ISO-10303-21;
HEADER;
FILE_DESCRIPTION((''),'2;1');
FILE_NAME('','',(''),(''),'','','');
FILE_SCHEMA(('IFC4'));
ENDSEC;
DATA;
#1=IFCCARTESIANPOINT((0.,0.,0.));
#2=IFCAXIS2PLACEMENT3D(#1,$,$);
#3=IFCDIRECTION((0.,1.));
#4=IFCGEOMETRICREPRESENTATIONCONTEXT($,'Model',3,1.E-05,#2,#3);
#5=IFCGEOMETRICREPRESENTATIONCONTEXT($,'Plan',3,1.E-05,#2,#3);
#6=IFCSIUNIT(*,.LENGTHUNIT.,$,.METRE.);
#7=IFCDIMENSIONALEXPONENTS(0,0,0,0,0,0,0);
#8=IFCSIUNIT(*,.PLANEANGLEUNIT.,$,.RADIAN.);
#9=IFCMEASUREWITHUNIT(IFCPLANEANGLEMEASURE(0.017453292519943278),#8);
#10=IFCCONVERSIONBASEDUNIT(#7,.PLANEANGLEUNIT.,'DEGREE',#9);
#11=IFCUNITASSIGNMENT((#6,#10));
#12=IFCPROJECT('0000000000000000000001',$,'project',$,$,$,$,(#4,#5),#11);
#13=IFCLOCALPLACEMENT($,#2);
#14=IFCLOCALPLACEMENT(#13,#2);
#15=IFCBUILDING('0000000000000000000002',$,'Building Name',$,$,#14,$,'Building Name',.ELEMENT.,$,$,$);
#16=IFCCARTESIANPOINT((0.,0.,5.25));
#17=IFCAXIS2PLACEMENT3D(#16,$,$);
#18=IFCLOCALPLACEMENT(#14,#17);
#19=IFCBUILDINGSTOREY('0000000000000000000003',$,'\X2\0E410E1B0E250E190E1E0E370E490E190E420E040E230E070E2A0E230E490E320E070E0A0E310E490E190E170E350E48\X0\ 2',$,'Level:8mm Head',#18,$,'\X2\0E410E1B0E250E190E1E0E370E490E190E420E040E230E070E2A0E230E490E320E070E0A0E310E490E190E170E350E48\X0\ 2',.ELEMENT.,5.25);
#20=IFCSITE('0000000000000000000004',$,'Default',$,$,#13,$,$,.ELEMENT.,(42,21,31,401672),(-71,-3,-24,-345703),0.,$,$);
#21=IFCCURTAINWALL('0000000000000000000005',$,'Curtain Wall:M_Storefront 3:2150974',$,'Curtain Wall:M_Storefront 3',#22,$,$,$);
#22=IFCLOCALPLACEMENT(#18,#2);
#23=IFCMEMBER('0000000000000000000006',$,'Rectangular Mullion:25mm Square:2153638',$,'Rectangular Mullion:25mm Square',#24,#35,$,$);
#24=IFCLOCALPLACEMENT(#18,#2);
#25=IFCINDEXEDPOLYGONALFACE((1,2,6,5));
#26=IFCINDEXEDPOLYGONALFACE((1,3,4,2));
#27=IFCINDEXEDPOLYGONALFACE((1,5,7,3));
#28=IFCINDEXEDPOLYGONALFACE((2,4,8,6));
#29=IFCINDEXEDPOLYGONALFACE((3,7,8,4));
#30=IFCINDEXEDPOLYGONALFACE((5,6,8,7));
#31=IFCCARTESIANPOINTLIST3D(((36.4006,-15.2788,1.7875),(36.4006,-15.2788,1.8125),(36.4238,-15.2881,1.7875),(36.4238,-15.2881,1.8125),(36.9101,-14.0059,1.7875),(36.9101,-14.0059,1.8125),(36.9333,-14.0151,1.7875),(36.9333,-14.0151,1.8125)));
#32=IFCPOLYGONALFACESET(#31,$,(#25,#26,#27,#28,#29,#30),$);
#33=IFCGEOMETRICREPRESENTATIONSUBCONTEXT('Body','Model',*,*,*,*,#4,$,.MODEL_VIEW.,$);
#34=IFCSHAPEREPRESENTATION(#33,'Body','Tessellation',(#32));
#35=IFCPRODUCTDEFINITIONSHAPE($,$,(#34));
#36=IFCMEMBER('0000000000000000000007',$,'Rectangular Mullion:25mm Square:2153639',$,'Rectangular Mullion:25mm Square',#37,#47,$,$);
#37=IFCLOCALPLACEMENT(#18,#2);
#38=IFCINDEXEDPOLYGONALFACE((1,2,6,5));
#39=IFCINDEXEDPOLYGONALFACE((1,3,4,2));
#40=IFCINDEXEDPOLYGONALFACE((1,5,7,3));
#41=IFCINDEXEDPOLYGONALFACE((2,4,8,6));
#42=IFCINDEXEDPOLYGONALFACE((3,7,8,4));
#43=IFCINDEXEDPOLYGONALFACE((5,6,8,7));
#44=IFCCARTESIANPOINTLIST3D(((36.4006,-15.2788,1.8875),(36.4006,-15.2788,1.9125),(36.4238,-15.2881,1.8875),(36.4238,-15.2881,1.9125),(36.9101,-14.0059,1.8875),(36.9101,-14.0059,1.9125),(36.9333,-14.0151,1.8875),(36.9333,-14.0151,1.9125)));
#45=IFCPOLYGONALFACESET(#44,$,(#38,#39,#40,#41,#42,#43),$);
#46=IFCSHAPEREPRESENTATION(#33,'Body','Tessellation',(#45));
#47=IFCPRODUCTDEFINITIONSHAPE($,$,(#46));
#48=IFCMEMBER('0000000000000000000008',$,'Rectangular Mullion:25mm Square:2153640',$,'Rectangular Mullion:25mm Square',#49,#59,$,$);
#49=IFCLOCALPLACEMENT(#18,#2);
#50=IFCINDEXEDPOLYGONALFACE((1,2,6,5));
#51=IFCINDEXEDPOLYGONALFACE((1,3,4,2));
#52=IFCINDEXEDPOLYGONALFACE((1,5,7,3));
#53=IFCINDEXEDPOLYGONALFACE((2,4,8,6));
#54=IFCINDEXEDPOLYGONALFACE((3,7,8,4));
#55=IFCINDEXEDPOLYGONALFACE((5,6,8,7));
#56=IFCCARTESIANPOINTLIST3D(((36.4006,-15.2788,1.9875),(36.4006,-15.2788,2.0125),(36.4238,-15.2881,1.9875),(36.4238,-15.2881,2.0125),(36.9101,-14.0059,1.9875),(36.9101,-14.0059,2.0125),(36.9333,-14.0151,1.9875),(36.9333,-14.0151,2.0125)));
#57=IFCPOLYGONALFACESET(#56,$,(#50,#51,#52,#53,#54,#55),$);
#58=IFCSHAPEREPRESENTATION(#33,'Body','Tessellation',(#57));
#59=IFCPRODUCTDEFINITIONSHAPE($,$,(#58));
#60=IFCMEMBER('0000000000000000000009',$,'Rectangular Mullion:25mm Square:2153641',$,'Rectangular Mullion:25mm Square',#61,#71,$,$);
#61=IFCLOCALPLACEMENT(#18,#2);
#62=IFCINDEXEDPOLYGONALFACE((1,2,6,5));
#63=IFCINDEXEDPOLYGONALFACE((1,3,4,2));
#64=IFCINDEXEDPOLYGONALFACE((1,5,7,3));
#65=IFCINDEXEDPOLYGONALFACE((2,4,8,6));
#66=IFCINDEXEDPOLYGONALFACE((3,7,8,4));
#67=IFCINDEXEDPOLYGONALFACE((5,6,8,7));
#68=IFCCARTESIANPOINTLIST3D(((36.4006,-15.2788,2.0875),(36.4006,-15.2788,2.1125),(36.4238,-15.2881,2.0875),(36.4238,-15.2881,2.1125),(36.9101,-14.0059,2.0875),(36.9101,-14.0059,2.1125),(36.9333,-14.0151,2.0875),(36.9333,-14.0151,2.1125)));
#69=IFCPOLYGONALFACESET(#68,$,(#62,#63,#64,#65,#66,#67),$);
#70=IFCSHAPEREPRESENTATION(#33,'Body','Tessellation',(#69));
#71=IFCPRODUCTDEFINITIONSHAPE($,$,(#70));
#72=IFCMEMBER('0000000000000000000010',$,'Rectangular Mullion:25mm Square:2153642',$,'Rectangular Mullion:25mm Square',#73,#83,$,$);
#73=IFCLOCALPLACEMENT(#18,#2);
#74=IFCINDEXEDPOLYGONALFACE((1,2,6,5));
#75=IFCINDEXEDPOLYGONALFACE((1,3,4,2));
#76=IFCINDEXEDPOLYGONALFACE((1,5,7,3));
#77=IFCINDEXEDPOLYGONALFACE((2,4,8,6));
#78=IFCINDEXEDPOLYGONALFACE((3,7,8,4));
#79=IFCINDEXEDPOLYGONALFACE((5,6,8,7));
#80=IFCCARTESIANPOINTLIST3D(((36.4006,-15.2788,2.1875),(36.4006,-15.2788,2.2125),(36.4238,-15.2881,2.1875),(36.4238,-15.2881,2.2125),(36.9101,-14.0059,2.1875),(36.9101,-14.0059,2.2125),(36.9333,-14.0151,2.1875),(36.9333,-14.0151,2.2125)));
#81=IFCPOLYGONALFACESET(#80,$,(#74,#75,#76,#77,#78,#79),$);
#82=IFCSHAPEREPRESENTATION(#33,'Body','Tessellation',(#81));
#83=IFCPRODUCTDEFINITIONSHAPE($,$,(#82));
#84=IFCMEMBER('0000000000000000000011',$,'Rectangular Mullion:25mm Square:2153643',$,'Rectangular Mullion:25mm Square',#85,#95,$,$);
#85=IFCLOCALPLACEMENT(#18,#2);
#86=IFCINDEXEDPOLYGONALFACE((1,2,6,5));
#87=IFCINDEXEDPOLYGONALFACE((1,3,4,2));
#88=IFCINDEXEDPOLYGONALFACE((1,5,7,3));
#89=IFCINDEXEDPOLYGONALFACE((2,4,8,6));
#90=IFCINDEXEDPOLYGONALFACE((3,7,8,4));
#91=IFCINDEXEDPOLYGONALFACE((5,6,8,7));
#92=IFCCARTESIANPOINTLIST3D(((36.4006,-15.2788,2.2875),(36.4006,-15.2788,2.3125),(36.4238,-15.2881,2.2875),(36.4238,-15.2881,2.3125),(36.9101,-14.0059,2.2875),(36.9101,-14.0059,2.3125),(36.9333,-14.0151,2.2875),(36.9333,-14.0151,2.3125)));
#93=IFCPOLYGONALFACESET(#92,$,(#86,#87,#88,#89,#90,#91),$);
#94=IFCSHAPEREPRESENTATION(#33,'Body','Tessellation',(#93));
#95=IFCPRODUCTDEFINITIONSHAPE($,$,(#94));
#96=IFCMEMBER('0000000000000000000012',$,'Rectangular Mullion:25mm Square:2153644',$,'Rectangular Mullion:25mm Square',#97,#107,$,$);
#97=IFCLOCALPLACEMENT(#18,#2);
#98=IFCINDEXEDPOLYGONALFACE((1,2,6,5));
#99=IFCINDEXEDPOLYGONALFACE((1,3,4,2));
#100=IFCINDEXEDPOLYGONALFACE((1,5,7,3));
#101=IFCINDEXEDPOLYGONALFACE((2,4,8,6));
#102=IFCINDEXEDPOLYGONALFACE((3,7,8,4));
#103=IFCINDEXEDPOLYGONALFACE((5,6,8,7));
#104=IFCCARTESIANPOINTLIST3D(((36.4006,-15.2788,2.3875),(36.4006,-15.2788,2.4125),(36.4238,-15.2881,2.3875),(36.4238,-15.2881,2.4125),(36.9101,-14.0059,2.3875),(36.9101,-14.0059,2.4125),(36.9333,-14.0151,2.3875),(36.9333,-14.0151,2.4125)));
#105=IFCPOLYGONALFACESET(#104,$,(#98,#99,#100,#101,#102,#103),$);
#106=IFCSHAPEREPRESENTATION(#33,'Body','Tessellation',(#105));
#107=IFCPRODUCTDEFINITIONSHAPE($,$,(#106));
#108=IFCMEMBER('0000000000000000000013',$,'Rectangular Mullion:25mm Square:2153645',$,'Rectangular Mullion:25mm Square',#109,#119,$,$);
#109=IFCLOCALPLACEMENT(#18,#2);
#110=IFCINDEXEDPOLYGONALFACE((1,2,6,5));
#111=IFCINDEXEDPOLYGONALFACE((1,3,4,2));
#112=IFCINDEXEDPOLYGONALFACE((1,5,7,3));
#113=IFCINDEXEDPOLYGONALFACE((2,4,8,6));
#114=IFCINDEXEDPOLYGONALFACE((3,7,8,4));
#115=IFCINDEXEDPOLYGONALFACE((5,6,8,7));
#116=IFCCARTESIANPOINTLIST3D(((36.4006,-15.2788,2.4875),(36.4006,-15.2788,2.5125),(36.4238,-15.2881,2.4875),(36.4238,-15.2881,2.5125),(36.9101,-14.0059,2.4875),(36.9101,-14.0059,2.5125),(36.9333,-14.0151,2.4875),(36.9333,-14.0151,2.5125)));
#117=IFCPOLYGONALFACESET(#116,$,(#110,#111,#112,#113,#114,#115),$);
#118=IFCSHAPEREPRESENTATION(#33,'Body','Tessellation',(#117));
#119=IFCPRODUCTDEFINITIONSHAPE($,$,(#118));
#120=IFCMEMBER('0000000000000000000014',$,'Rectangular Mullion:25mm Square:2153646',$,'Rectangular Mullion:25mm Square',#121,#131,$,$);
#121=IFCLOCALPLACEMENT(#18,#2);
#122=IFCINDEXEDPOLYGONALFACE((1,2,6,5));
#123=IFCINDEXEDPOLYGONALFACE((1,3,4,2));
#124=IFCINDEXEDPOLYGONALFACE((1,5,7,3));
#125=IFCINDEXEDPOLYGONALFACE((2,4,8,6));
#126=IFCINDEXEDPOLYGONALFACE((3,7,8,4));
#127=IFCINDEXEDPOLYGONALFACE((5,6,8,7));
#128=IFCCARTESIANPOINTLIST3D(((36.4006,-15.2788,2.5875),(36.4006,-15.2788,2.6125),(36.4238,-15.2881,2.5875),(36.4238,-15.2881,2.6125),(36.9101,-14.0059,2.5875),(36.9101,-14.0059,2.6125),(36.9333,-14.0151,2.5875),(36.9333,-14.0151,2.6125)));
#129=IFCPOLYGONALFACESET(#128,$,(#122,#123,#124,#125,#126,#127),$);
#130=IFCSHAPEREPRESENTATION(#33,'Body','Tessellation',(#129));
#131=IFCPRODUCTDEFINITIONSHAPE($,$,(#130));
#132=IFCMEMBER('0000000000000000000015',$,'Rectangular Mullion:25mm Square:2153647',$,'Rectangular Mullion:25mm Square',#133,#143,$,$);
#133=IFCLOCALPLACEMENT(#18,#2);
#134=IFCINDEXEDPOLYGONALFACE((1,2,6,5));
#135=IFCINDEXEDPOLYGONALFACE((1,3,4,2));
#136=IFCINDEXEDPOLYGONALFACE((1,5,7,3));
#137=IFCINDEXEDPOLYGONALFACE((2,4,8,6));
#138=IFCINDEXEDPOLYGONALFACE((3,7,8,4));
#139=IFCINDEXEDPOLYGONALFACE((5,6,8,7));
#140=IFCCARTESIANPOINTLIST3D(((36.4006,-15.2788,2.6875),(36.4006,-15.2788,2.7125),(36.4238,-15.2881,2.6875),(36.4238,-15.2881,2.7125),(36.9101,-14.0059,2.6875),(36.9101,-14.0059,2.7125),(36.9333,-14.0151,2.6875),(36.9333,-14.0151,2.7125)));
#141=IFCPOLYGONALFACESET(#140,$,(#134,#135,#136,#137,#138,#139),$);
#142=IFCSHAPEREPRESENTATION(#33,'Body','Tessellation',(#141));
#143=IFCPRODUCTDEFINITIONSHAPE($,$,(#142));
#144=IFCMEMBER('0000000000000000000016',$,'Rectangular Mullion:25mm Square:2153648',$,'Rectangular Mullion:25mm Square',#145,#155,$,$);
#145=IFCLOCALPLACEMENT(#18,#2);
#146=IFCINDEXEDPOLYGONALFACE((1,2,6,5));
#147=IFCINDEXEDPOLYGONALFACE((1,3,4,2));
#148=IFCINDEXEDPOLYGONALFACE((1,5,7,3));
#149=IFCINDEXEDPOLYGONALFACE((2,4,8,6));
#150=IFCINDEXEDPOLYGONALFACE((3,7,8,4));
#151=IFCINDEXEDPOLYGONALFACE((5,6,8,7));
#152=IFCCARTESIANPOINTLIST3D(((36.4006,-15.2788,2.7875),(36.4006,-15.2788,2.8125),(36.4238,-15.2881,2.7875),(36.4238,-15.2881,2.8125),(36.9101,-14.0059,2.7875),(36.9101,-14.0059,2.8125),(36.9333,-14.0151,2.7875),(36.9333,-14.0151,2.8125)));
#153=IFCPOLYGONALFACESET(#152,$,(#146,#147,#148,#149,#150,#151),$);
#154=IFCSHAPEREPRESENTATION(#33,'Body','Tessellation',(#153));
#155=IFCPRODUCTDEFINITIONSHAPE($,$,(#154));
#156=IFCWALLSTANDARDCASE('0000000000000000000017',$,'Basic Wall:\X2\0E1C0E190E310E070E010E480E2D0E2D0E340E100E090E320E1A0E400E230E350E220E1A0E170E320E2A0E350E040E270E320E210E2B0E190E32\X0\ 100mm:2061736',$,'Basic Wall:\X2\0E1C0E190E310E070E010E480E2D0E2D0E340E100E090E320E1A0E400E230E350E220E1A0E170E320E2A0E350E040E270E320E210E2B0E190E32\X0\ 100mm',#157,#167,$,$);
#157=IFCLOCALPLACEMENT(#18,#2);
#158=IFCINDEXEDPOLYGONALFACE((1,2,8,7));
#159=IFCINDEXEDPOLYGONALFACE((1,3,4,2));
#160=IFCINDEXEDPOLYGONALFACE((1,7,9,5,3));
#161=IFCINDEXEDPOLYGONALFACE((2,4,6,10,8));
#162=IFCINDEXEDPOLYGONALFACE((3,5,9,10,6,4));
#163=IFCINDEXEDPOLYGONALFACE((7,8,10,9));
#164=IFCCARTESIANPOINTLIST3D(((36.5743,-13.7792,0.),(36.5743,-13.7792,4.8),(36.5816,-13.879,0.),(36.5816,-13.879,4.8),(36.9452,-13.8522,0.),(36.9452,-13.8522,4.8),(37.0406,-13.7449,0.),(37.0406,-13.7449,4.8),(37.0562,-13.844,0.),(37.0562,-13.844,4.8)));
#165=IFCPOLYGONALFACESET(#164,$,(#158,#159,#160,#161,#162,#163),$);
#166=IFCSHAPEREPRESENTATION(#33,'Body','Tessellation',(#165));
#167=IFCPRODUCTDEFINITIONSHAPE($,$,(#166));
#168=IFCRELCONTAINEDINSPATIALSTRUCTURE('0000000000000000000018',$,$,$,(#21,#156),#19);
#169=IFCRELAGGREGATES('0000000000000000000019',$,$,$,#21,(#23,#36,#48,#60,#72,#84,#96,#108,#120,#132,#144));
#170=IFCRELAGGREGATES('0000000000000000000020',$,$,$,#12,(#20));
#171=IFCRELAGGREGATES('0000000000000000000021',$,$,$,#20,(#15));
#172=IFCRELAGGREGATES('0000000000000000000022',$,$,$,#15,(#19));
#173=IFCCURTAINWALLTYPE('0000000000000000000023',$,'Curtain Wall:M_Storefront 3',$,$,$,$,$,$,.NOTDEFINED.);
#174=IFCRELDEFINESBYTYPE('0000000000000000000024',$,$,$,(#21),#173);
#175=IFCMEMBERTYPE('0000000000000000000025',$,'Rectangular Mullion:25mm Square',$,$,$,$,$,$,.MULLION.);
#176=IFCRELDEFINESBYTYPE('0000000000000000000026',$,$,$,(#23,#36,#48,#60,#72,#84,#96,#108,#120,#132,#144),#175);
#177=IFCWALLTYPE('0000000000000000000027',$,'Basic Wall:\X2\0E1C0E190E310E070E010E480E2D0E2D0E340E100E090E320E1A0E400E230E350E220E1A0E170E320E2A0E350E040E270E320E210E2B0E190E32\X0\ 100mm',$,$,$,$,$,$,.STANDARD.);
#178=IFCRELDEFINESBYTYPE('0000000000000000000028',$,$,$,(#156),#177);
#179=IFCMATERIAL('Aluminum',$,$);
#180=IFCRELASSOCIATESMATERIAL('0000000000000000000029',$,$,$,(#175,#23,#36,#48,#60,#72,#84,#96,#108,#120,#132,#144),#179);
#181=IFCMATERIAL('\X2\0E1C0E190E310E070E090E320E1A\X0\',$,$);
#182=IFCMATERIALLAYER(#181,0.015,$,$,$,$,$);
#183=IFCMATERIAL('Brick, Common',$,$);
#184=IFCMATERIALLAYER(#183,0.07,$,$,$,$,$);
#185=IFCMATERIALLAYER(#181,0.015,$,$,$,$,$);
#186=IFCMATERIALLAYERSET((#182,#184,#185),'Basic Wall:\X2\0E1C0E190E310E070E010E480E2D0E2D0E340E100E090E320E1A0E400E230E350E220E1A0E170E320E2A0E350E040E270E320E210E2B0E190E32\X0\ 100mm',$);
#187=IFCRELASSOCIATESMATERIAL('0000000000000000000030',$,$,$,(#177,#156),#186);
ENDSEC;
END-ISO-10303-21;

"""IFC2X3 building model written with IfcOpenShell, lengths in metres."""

from ifc_helpers import new_model, entity, si_unit, converted_unit, direction, frame, frame_2d, origin, place, context, subcontext, project, spatial, polyline, rectangle, outline, extrude, source, transform, mapped, material, layer, layer_set, layer_usage, type_object, type_shapes, element, aggregate, save


model = new_model("IFC2X3")

# Units and contexts
model_context = context("Model", 3, precision=1e-05, world=origin(), true_north=direction((0.0, 1.0)))
plan_context = context("Plan", 3, precision=1e-05, world=origin(), true_north=direction((0.0, 1.0)))
body_context = subcontext(model_context, "Body", "Model", "MODEL_VIEW")
ifc_project = project(units=[si_unit("LENGTHUNIT", "METRE"), converted_unit("PLANEANGLEUNIT", "DEGREE", entity("IfcPlaneAngleMeasure", 0.017453292519943278), si_unit("PLANEANGLEUNIT", "RADIAN"), dimensions=[0, 0, 0, 0, 0, 0, 0])], contexts=[model_context, plan_context])

# Site, building, storey
site_placement = place(None, origin())
site = spatial("IfcSite", under=ifc_project, at=site_placement, Name="Default", CompositionType="ELEMENT", RefLatitude=(42, 21, 31, 401672), RefLongitude=(-71, -3, -24, -345703), RefElevation=0.0)
building_placement = place(site_placement, origin())
building = spatial("IfcBuilding", under=site, at=building_placement, Name="Building Name", LongName="Building Name", CompositionType="ELEMENT")
storey_placement = place(building_placement, frame((0.0, 0.0, 5.25)))
storey = spatial("IfcBuildingStorey", under=building, at=storey_placement, Name="แปลนพื้นโครงสร้างชั้นที่ 2", ObjectType="Level:8mm Head", LongName="แปลนพื้นโครงสร้างชั้นที่ 2", CompositionType="ELEMENT", Elevation=5.25)

# Curtain wall, members
curtain_wall_type = type_object("IfcCurtainWallType", Name="Curtain Wall:M_Storefront 3", PredefinedType="NOTDEFINED")
curtain_wall_placement = place(storey_placement, frame((0.0, 0.0, -5.25)))
curtain_wall = element("IfcCurtainWall", 1, at=curtain_wall_placement, inside=storey, type_object=curtain_wall_type, Name="Curtain Wall:M_Storefront 3:2150974", ObjectType="Curtain Wall:M_Storefront 3")
ifc_material_1 = material(Name="Aluminum")
member_type_1 = type_object("IfcMemberType", Name="Rectangular Mullion:25mm Square", PredefinedType="MULLION", material=ifc_material_1)
shared_shape_1 = source(origin(), body_context, "Body", "SweptSolid", [
    extrude(rectangle(XDim=0.025, YDim=0.025, at=frame_2d((0.0, 0.0), x_axis=(1.0, 0.0))), frame((0.0, 0.0, -1.3712), z_axis=(0.0, 0.0, 1.0), x_axis=(-1.0, 0.0, 0.0)), (0.0, 0.0, 1.0), 1.3712),
])
type_shapes(member_type_1, [shared_shape_1])
member_1_placement = place(curtain_wall_placement, frame((36.9217, -14.0105, 7.05), z_axis=(0.371573, 0.928404, 0.0), x_axis=(0.0, 0.0, 1.0)))
member_1 = element("IfcMember", 2, at=member_1_placement, type_object=member_type_1, material=ifc_material_1, Name="Rectangular Mullion:25mm Square:2153638", ObjectType="Rectangular Mullion:25mm Square", context=body_context, shape_type="MappedRepresentation", body=[
    mapped(shared_shape_1, transform((0.0, 0.0, 0.0), scale=1.0)),
])
member_2_placement = place(curtain_wall_placement, frame((36.9217, -14.0105, 7.15), z_axis=(0.371573, 0.928404, 0.0), x_axis=(0.0, 0.0, 1.0)))
member_2 = element("IfcMember", 3, at=member_2_placement, type_object=member_type_1, material=ifc_material_1, Name="Rectangular Mullion:25mm Square:2153639", ObjectType="Rectangular Mullion:25mm Square", context=body_context, shape_type="MappedRepresentation", body=[
    mapped(shared_shape_1, transform((0.0, 0.0, 0.0), scale=1.0)),
])
member_3_placement = place(curtain_wall_placement, frame((36.9217, -14.0105, 7.25), z_axis=(0.371573, 0.928404, 0.0), x_axis=(0.0, 0.0, 1.0)))
member_3 = element("IfcMember", 4, at=member_3_placement, type_object=member_type_1, material=ifc_material_1, Name="Rectangular Mullion:25mm Square:2153640", ObjectType="Rectangular Mullion:25mm Square", context=body_context, shape_type="MappedRepresentation", body=[
    mapped(shared_shape_1, transform((0.0, 0.0, 0.0), scale=1.0)),
])
member_4_placement = place(curtain_wall_placement, frame((36.9217, -14.0105, 7.35), z_axis=(0.371573, 0.928404, 0.0), x_axis=(0.0, 0.0, 1.0)))
member_4 = element("IfcMember", 5, at=member_4_placement, type_object=member_type_1, material=ifc_material_1, Name="Rectangular Mullion:25mm Square:2153641", ObjectType="Rectangular Mullion:25mm Square", context=body_context, shape_type="MappedRepresentation", body=[
    mapped(shared_shape_1, transform((0.0, 0.0, 0.0), scale=1.0)),
])
member_5_placement = place(curtain_wall_placement, frame((36.9217, -14.0105, 7.45), z_axis=(0.371573, 0.928404, 0.0), x_axis=(0.0, 0.0, 1.0)))
member_5 = element("IfcMember", 6, at=member_5_placement, type_object=member_type_1, material=ifc_material_1, Name="Rectangular Mullion:25mm Square:2153642", ObjectType="Rectangular Mullion:25mm Square", context=body_context, shape_type="MappedRepresentation", body=[
    mapped(shared_shape_1, transform((0.0, 0.0, 0.0), scale=1.0)),
])
member_6_placement = place(curtain_wall_placement, frame((36.9217, -14.0105, 7.55), z_axis=(0.371573, 0.928404, 0.0), x_axis=(0.0, 0.0, 1.0)))
member_6 = element("IfcMember", 7, at=member_6_placement, type_object=member_type_1, material=ifc_material_1, Name="Rectangular Mullion:25mm Square:2153643", ObjectType="Rectangular Mullion:25mm Square", context=body_context, shape_type="MappedRepresentation", body=[
    mapped(shared_shape_1, transform((0.0, 0.0, 0.0), scale=1.0)),
])
member_7_placement = place(curtain_wall_placement, frame((36.9217, -14.0105, 7.65), z_axis=(0.371573, 0.928404, 0.0), x_axis=(0.0, 0.0, 1.0)))
member_7 = element("IfcMember", 8, at=member_7_placement, type_object=member_type_1, material=ifc_material_1, Name="Rectangular Mullion:25mm Square:2153644", ObjectType="Rectangular Mullion:25mm Square", context=body_context, shape_type="MappedRepresentation", body=[
    mapped(shared_shape_1, transform((0.0, 0.0, 0.0), scale=1.0)),
])
member_8_placement = place(curtain_wall_placement, frame((36.9217, -14.0105, 7.75), z_axis=(0.371573, 0.928404, 0.0), x_axis=(0.0, 0.0, 1.0)))
member_8 = element("IfcMember", 9, at=member_8_placement, type_object=member_type_1, material=ifc_material_1, Name="Rectangular Mullion:25mm Square:2153645", ObjectType="Rectangular Mullion:25mm Square", context=body_context, shape_type="MappedRepresentation", body=[
    mapped(shared_shape_1, transform((0.0, 0.0, 0.0), scale=1.0)),
])
member_9_placement = place(curtain_wall_placement, frame((36.9217, -14.0105, 7.85), z_axis=(0.371573, 0.928404, 0.0), x_axis=(0.0, 0.0, 1.0)))
member_9 = element("IfcMember", 10, at=member_9_placement, type_object=member_type_1, material=ifc_material_1, Name="Rectangular Mullion:25mm Square:2153646", ObjectType="Rectangular Mullion:25mm Square", context=body_context, shape_type="MappedRepresentation", body=[
    mapped(shared_shape_1, transform((0.0, 0.0, 0.0), scale=1.0)),
])
member_10_placement = place(curtain_wall_placement, frame((36.9217, -14.0105, 7.95), z_axis=(0.371573, 0.928404, 0.0), x_axis=(0.0, 0.0, 1.0)))
member_10 = element("IfcMember", 11, at=member_10_placement, type_object=member_type_1, material=ifc_material_1, Name="Rectangular Mullion:25mm Square:2153647", ObjectType="Rectangular Mullion:25mm Square", context=body_context, shape_type="MappedRepresentation", body=[
    mapped(shared_shape_1, transform((0.0, 0.0, 0.0), scale=1.0)),
])
member_11_placement = place(curtain_wall_placement, frame((36.9217, -14.0105, 8.05), z_axis=(0.371573, 0.928404, 0.0), x_axis=(0.0, 0.0, 1.0)))
member_11 = element("IfcMember", 12, at=member_11_placement, type_object=member_type_1, material=ifc_material_1, Name="Rectangular Mullion:25mm Square:2153648", ObjectType="Rectangular Mullion:25mm Square", context=body_context, shape_type="MappedRepresentation", body=[
    mapped(shared_shape_1, transform((0.0, 0.0, 0.0), scale=1.0)),
])
aggregate(curtain_wall, [member_1, member_2, member_3, member_4, member_5, member_6, member_7, member_8, member_9, member_10, member_11])

# Wall
ifc_material_2 = material(Name="ผนังฉาบ")
ifc_layer_1 = layer(ifc_material_2, 0.015)
ifc_material_3 = material(Name="Brick, Common")
ifc_layer_2 = layer(ifc_material_3, 0.07)
ifc_layer_3 = layer(ifc_material_2, 0.015)
ifc_layer_set = layer_set([ifc_layer_1, ifc_layer_2, ifc_layer_3], Name="Basic Wall:ผนังก่ออิฐฉาบเรียบทาสีความหนา 100mm")
ifc_layer_usage = layer_usage(ifc_layer_set, "AXIS2", "POSITIVE", -0.05)
wall_type = type_object("IfcWallType", Name="Basic Wall:ผนังก่ออิฐฉาบเรียบทาสีความหนา 100mm", PredefinedType="STANDARD", material=ifc_layer_set)
wall_placement = place(storey_placement, frame((36.578, -13.8291, 0.0), z_axis=(0.0, 0.0, 1.0), x_axis=(0.997301, 0.073417, 0.0)))
element("IfcWallStandardCase", 13, at=wall_placement, inside=storey, type_object=wall_type, material=ifc_layer_usage, Name="Basic Wall:ผนังก่ออิฐฉาบเรียบทาสีความหนา 100mm:2061736", ObjectType="Basic Wall:ผนังก่ออิฐฉาบเรียบทาสีความหนา 100mm", context=body_context, shape_type="SweptSolid", body=[
    extrude(outline(polyline([(0.4759, -0.05), (0.4676, 0.05), (0.0, 0.05), (0.0, -0.05), (0.3646, -0.05), (0.4759, -0.05)])), origin(), (0.0, 0.0, 1.0), 4.8),
])

save(model, "model.ifc")
